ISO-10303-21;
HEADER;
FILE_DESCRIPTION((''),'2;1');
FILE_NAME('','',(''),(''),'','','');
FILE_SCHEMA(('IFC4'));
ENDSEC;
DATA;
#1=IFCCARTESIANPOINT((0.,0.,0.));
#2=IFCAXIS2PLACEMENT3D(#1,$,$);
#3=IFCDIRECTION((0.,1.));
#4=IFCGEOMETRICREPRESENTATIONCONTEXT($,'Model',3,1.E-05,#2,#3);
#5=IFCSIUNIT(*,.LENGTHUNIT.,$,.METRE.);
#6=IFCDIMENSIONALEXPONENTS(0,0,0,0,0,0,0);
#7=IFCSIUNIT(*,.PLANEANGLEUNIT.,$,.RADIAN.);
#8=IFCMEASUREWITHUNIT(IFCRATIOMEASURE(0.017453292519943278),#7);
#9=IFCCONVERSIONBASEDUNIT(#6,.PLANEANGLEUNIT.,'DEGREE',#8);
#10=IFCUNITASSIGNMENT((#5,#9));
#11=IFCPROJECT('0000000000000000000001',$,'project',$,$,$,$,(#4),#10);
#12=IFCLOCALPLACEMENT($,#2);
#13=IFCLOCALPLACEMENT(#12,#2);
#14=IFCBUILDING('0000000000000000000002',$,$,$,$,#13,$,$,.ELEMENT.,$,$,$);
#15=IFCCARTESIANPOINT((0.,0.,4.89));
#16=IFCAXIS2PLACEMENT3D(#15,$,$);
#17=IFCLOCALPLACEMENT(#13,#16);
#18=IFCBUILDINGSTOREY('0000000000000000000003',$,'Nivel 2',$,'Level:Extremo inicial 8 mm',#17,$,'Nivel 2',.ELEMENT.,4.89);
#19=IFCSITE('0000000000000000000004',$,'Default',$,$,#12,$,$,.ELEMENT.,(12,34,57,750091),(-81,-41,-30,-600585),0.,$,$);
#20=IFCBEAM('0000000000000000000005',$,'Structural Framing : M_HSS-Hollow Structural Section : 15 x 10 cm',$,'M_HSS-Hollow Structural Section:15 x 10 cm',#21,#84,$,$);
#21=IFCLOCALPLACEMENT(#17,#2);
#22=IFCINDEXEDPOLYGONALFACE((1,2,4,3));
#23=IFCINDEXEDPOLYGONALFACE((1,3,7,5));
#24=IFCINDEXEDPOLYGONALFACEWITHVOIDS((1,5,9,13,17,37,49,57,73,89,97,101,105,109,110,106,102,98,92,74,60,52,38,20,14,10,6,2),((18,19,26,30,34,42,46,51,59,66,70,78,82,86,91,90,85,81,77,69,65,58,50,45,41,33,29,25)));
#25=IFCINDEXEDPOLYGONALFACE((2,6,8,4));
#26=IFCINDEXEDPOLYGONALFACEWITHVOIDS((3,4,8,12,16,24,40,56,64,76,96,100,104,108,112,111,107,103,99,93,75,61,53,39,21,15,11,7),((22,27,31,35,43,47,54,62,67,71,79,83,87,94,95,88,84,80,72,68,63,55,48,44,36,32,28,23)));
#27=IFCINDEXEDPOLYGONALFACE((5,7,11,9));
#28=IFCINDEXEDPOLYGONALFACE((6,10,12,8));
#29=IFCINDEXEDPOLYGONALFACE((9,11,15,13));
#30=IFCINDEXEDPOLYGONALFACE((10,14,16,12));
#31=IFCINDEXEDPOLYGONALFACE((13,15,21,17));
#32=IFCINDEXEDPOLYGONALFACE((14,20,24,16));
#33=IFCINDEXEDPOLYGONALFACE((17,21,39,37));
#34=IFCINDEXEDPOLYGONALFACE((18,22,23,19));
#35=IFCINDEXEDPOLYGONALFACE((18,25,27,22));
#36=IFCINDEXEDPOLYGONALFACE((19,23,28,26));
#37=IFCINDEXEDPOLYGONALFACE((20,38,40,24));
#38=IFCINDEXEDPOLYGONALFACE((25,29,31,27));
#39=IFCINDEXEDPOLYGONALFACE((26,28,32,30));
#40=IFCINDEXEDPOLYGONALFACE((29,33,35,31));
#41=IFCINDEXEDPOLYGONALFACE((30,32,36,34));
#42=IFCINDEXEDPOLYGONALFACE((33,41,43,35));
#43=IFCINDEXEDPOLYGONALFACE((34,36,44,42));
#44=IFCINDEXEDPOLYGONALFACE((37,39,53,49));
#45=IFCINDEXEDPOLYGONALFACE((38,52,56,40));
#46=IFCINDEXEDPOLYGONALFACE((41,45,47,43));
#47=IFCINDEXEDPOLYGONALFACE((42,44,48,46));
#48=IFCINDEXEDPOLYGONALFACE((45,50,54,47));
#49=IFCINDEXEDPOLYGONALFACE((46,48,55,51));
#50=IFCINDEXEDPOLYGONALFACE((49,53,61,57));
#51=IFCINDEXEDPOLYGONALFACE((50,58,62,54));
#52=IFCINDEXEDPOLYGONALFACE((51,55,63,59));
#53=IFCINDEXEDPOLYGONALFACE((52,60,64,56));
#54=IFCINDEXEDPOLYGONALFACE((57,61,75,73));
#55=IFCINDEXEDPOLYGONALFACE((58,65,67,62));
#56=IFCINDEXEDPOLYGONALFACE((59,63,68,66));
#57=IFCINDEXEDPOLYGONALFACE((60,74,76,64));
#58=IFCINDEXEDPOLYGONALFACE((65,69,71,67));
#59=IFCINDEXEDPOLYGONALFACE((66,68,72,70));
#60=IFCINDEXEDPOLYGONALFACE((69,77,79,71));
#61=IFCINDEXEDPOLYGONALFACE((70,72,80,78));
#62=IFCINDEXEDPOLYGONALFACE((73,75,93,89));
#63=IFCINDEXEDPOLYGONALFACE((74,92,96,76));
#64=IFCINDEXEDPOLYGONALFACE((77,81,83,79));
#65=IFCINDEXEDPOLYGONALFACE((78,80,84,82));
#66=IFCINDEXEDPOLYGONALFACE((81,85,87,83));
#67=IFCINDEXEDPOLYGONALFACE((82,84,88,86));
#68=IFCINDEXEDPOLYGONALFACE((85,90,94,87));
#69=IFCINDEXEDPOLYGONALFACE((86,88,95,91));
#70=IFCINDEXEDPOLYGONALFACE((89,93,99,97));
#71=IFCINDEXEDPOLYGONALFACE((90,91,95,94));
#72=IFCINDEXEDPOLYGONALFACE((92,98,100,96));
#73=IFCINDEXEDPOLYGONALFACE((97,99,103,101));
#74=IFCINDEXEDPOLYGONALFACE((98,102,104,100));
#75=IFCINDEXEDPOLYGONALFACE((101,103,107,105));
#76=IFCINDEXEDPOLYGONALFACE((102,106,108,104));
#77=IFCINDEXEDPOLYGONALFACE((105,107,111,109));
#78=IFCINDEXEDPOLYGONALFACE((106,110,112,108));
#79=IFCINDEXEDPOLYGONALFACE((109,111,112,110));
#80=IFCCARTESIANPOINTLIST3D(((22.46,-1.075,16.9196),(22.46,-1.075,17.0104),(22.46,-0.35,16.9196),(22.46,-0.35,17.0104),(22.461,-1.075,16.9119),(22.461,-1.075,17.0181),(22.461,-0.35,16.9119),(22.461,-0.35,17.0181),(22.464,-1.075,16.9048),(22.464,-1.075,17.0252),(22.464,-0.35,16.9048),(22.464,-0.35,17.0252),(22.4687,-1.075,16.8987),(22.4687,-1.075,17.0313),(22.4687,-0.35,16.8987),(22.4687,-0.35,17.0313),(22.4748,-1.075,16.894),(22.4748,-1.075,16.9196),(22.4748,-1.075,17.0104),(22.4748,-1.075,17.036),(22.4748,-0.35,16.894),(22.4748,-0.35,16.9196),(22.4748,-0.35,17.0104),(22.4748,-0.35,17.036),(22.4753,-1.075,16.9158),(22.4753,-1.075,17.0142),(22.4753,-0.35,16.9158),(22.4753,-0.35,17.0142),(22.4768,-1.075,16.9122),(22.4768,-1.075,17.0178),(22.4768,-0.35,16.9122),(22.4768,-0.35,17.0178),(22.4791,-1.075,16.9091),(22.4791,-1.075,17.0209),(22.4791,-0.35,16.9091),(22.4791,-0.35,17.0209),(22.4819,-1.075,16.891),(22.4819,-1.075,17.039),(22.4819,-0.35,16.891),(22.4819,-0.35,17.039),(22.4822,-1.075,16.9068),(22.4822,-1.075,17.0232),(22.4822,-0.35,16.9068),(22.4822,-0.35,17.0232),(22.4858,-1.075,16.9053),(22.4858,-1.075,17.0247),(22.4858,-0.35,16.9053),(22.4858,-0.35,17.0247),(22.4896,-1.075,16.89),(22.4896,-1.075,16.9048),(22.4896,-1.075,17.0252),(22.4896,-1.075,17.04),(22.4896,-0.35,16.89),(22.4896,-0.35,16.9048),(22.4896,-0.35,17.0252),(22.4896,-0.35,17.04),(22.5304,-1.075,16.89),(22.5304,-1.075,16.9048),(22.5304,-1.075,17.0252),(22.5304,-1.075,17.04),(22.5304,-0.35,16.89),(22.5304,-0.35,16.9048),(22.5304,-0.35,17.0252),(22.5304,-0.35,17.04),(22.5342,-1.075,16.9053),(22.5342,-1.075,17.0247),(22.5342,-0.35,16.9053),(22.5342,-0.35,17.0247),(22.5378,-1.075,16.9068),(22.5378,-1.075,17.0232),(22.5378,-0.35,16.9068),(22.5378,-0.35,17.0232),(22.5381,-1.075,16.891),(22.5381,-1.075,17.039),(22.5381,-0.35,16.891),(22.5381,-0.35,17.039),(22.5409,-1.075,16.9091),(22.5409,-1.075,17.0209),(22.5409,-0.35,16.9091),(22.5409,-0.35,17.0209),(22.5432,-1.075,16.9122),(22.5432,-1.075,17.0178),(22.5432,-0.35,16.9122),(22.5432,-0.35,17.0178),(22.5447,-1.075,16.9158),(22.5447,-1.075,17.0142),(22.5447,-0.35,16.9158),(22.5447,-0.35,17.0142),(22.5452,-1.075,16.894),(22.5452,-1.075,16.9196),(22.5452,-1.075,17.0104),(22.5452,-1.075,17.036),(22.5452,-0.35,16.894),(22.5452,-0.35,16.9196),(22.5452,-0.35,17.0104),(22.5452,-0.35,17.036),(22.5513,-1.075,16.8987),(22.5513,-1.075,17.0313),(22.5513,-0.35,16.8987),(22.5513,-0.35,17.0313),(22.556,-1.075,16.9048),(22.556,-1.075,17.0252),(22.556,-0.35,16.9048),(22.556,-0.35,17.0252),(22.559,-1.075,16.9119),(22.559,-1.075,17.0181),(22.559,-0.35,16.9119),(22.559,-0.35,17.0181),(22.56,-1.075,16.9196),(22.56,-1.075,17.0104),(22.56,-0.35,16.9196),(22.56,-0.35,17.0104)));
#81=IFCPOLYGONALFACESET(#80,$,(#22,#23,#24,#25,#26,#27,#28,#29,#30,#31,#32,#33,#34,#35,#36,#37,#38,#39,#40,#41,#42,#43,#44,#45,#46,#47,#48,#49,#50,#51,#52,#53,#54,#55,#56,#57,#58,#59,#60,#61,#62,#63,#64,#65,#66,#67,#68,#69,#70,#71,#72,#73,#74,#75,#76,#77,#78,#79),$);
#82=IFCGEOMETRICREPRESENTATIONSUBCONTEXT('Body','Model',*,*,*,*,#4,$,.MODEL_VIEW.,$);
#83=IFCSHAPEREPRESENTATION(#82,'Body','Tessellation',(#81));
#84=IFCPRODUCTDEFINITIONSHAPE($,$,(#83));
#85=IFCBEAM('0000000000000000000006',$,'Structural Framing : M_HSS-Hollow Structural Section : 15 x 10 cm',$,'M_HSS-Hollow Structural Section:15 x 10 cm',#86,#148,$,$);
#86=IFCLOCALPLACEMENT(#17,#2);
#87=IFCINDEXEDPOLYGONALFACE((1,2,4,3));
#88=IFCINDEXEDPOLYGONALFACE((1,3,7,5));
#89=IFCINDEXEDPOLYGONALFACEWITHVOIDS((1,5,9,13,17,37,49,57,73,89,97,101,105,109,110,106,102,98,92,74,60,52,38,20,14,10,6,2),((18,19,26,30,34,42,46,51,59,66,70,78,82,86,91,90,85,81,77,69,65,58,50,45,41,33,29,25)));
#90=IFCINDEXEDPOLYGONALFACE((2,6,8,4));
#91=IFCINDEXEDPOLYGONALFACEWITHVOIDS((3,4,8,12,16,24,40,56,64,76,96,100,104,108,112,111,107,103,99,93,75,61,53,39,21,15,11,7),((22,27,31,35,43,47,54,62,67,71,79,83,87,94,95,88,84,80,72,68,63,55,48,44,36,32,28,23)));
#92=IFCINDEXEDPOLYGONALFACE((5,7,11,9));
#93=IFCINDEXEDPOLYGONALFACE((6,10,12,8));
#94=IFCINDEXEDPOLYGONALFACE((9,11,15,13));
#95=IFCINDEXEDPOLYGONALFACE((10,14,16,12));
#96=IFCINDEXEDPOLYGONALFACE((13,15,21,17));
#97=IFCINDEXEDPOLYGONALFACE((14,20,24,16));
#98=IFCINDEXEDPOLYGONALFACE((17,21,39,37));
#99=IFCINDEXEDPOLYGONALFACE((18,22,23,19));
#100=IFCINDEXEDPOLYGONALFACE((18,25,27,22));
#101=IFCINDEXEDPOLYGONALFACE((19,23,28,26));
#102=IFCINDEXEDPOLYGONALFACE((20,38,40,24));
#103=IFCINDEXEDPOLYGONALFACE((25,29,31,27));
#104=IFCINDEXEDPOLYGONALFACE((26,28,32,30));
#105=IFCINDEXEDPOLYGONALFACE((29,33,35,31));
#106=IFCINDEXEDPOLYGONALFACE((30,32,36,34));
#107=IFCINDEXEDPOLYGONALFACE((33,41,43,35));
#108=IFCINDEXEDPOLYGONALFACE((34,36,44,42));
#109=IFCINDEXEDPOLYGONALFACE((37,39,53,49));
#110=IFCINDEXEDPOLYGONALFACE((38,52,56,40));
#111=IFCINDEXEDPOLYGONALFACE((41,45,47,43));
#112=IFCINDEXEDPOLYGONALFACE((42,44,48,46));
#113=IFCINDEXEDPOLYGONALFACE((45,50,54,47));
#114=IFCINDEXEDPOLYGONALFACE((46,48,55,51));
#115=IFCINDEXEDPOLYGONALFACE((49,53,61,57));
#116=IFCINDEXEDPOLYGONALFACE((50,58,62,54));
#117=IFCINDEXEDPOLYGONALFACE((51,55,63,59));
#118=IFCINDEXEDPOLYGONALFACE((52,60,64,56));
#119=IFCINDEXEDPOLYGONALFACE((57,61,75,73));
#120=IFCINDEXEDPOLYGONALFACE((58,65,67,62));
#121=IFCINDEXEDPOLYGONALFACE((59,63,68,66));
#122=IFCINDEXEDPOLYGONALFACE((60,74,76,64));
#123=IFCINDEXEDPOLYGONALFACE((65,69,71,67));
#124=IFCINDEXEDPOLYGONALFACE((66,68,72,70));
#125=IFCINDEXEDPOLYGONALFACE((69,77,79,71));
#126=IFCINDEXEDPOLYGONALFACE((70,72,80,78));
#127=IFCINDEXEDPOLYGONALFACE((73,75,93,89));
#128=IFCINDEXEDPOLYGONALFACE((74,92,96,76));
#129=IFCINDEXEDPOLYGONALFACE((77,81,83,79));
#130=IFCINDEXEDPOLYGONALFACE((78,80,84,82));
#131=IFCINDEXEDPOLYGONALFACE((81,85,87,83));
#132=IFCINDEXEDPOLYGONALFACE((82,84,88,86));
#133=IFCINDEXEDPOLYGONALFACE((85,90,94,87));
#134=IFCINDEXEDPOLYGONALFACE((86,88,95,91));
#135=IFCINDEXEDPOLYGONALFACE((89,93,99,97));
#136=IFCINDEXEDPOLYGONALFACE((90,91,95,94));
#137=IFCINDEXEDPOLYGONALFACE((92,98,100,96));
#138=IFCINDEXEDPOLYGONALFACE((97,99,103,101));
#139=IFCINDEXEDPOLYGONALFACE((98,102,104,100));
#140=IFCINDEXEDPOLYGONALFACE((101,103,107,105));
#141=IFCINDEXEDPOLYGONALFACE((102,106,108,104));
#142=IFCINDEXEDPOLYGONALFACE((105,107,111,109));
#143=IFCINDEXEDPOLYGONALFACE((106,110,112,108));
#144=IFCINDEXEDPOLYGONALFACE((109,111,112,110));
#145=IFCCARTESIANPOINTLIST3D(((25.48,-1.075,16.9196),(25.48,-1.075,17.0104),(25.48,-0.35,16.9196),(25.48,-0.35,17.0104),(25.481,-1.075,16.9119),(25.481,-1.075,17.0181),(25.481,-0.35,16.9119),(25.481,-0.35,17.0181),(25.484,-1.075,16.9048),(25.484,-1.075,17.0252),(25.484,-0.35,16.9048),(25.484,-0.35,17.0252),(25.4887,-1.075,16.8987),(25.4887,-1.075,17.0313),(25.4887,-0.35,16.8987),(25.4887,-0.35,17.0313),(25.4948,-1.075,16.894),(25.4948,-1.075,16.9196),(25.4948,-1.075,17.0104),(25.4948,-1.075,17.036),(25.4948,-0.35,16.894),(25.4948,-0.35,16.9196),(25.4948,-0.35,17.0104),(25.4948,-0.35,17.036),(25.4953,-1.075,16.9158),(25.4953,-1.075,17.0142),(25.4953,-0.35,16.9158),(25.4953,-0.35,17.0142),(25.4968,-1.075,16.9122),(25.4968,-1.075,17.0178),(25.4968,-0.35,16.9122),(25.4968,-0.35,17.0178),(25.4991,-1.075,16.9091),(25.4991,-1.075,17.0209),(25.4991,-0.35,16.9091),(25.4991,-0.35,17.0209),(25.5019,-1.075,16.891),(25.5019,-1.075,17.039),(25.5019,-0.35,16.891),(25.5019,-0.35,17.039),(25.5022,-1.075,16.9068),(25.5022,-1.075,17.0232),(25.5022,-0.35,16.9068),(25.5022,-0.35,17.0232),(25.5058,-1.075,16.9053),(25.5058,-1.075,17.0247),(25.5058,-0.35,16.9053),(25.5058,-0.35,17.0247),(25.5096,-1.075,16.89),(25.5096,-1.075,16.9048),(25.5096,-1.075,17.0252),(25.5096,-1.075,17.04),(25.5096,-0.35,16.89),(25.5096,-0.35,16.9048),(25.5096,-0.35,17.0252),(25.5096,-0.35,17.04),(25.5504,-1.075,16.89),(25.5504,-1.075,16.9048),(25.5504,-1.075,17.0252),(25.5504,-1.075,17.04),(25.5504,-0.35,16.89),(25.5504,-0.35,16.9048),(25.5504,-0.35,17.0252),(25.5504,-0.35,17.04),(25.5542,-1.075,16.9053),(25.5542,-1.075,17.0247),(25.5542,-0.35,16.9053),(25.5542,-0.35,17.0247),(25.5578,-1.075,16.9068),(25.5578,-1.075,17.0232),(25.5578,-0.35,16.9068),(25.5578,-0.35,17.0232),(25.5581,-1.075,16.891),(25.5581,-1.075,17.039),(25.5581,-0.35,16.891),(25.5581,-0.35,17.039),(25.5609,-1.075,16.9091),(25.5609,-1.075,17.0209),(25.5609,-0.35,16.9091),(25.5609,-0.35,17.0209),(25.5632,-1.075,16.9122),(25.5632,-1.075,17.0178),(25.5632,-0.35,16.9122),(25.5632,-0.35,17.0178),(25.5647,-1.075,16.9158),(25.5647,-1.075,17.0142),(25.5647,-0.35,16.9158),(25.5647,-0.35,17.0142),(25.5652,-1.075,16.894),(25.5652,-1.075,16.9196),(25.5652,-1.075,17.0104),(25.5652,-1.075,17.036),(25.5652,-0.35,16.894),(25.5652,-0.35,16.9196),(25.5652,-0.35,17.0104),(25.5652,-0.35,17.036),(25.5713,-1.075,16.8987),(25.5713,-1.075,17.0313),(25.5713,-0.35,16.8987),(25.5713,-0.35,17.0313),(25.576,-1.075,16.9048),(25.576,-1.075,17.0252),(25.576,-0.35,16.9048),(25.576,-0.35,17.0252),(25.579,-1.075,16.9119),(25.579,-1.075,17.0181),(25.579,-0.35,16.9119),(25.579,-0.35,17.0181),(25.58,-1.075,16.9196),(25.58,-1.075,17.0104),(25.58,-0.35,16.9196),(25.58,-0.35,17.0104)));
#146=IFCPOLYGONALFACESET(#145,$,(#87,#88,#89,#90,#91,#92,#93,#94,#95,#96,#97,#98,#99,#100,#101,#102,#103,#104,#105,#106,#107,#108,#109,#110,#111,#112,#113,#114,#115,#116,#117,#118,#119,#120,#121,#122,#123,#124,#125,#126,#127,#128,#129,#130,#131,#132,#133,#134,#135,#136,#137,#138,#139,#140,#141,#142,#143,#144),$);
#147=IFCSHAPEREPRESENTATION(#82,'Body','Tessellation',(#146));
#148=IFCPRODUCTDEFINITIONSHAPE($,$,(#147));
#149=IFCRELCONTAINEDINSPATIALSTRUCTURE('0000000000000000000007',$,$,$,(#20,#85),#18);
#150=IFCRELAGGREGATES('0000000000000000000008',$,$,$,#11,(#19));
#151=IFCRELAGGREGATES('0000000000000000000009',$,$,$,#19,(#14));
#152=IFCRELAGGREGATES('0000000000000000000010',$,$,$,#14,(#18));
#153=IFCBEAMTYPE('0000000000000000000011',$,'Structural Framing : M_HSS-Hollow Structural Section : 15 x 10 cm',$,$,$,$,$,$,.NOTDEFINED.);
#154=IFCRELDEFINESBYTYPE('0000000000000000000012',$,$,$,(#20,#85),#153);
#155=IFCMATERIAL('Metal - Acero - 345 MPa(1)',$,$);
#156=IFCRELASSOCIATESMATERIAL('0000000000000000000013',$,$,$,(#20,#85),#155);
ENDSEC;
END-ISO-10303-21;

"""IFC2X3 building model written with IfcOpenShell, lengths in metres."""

from ifc_helpers import new_model, entity, si_unit, converted_unit, direction, frame, frame_2d, origin, place, context, subcontext, project, spatial, polyline, circle_curve, parameter, trimmed, segment, composite_curve, outline, extrude, material, type_object, element, save


model = new_model("IFC2X3")

# Units and contexts
model_context = context("Model", 3, precision=1e-05, world=origin(), true_north=direction((0.0, 1.0)))
body_context = subcontext(model_context, "Body", "Model", "MODEL_VIEW")
ifc_project = project(units=[si_unit("LENGTHUNIT", "METRE"), converted_unit("PLANEANGLEUNIT", "DEGREE", entity("IfcRatioMeasure", 0.017453292519943278), si_unit("PLANEANGLEUNIT", "RADIAN"), dimensions=[0, 0, 0, 0, 0, 0, 0])], contexts=[model_context])

# Site, building, storey
site_placement = place(None, origin())
site = spatial("IfcSite", under=ifc_project, at=site_placement, Name="Default", CompositionType="ELEMENT", RefLatitude=(12, 34, 57, 750091), RefLongitude=(-81, -41, -30, -600585), RefElevation=0.0)
building_placement = place(site_placement, origin())
building = spatial("IfcBuilding", under=site, at=building_placement, CompositionType="ELEMENT")
storey_placement = place(building_placement, frame((0.0, 0.0, 4.89)))
storey = spatial("IfcBuildingStorey", under=building, at=storey_placement, Name="Nivel 2", ObjectType="Level:Extremo inicial 8 mm", LongName="Nivel 2", CompositionType="ELEMENT", Elevation=4.89)

# Beams
ifc_material_1 = material(Name="Metal - Acero - 345 MPa(1)")
beam_type_1 = type_object("IfcBeamType", Name="Structural Framing : M_HSS-Hollow Structural Section : 15 x 10 cm", PredefinedType="NOTDEFINED")
beam_1_placement = place(storey_placement, frame((22.51, -1.425, 17.04), z_axis=(0.0, 0.0, 1.0), x_axis=(0.0, 1.0, 0.0)))
element("IfcBeam", 1, at=beam_1_placement, inside=storey, type_object=beam_type_1, material=ifc_material_1, Name="Structural Framing : M_HSS-Hollow Structural Section : 15 x 10 cm", ObjectType="M_HSS-Hollow Structural Section:15 x 10 cm", context=body_context, shape_type="SweptSolid", body=[
    extrude(outline(composite_curve([segment(trimmed(circle_curve(frame_2d((-0.0204, -0.0454), x_axis=(1.0, 0.0)), 0.0296), [parameter(180.0)], [parameter(270.0)], True, "PARAMETER"), True, "CONTINUOUS"), segment(polyline([(-0.0204, -0.075), (0.0204, -0.075)]), True, "CONTINUOUS"), segment(trimmed(circle_curve(frame_2d((0.0204, -0.0454), x_axis=(1.0, 0.0)), 0.0296), [parameter(270.0)], [parameter(0.0)], True, "PARAMETER"), True, "CONTINUOUS"), segment(polyline([(0.05, -0.0454), (0.05, 0.0454)]), True, "CONTINUOUS"), segment(trimmed(circle_curve(frame_2d((0.0204, 0.0454), x_axis=(1.0, 0.0)), 0.0296), [parameter(360.0)], [parameter(90.0)], True, "PARAMETER"), True, "CONTINUOUS"), segment(polyline([(0.0204, 0.075), (-0.0204, 0.075)]), True, "CONTINUOUS"), segment(trimmed(circle_curve(frame_2d((-0.0204, 0.0454), x_axis=(1.0, 0.0)), 0.0296), [parameter(90.0)], [parameter(180.0)], True, "PARAMETER"), True, "CONTINUOUS"), segment(polyline([(-0.05, 0.0454), (-0.05, -0.0454)]), True, "CONTINUOUS")], self_intersect=False), holes=[composite_curve([segment(polyline([(0.0204, -0.0602), (-0.0204, -0.0602)]), True, "CONTINUOUS"), segment(trimmed(circle_curve(frame_2d((-0.0204, -0.0454), x_axis=(1.0, 0.0)), 0.0148), [parameter(180.0)], [parameter(270.0)], True, "PARAMETER"), False, "CONTINUOUS"), segment(polyline([(-0.0352, -0.0454), (-0.0352, 0.0454)]), True, "CONTINUOUS"), segment(trimmed(circle_curve(frame_2d((-0.0204, 0.0454), x_axis=(1.0, 0.0)), 0.0148), [parameter(90.0)], [parameter(180.0)], True, "PARAMETER"), False, "CONTINUOUS"), segment(polyline([(-0.0204, 0.0602), (0.0204, 0.0602)]), True, "CONTINUOUS"), segment(trimmed(circle_curve(frame_2d((0.0204, 0.0454), x_axis=(1.0, 0.0)), 0.0148), [parameter(0.0)], [parameter(90.0)], True, "PARAMETER"), False, "CONTINUOUS"), segment(polyline([(0.0352, 0.0454), (0.0352, -0.0454)]), True, "CONTINUOUS"), segment(trimmed(circle_curve(frame_2d((0.0204, -0.0454), x_axis=(1.0, 0.0)), 0.0148), [parameter(270.0)], [parameter(0.0)], True, "PARAMETER"), False, "CONTINUOUS")], self_intersect=False)]), frame((0.35, 0.0, -0.075), z_axis=(1.0, 0.0, 0.0), x_axis=(0.0, -1.0, 0.0)), (0.0, 0.0, 1.0), 0.725),
])
beam_2_placement = place(storey_placement, frame((25.53, -1.425, 17.04), z_axis=(0.0, 0.0, 1.0), x_axis=(0.0, 1.0, 0.0)))
element("IfcBeam", 2, at=beam_2_placement, inside=storey, type_object=beam_type_1, material=ifc_material_1, Name="Structural Framing : M_HSS-Hollow Structural Section : 15 x 10 cm", ObjectType="M_HSS-Hollow Structural Section:15 x 10 cm", context=body_context, shape_type="SweptSolid", body=[
    extrude(outline(composite_curve([segment(trimmed(circle_curve(frame_2d((-0.0204, -0.0454), x_axis=(1.0, 0.0)), 0.0296), [parameter(180.0)], [parameter(270.0)], True, "PARAMETER"), True, "CONTINUOUS"), segment(polyline([(-0.0204, -0.075), (0.0204, -0.075)]), True, "CONTINUOUS"), segment(trimmed(circle_curve(frame_2d((0.0204, -0.0454), x_axis=(1.0, 0.0)), 0.0296), [parameter(270.0)], [parameter(0.0)], True, "PARAMETER"), True, "CONTINUOUS"), segment(polyline([(0.05, -0.0454), (0.05, 0.0454)]), True, "CONTINUOUS"), segment(trimmed(circle_curve(frame_2d((0.0204, 0.0454), x_axis=(1.0, 0.0)), 0.0296), [parameter(360.0)], [parameter(90.0)], True, "PARAMETER"), True, "CONTINUOUS"), segment(polyline([(0.0204, 0.075), (-0.0204, 0.075)]), True, "CONTINUOUS"), segment(trimmed(circle_curve(frame_2d((-0.0204, 0.0454), x_axis=(1.0, 0.0)), 0.0296), [parameter(90.0)], [parameter(180.0)], True, "PARAMETER"), True, "CONTINUOUS"), segment(polyline([(-0.05, 0.0454), (-0.05, -0.0454)]), True, "CONTINUOUS")], self_intersect=False), holes=[composite_curve([segment(polyline([(0.0204, -0.0602), (-0.0204, -0.0602)]), True, "CONTINUOUS"), segment(trimmed(circle_curve(frame_2d((-0.0204, -0.0454), x_axis=(1.0, 0.0)), 0.0148), [parameter(180.0)], [parameter(270.0)], True, "PARAMETER"), False, "CONTINUOUS"), segment(polyline([(-0.0352, -0.0454), (-0.0352, 0.0454)]), True, "CONTINUOUS"), segment(trimmed(circle_curve(frame_2d((-0.0204, 0.0454), x_axis=(1.0, 0.0)), 0.0148), [parameter(90.0)], [parameter(180.0)], True, "PARAMETER"), False, "CONTINUOUS"), segment(polyline([(-0.0204, 0.0602), (0.0204, 0.0602)]), True, "CONTINUOUS"), segment(trimmed(circle_curve(frame_2d((0.0204, 0.0454), x_axis=(1.0, 0.0)), 0.0148), [parameter(0.0)], [parameter(90.0)], True, "PARAMETER"), False, "CONTINUOUS"), segment(polyline([(0.0352, 0.0454), (0.0352, -0.0454)]), True, "CONTINUOUS"), segment(trimmed(circle_curve(frame_2d((0.0204, -0.0454), x_axis=(1.0, 0.0)), 0.0148), [parameter(270.0)], [parameter(0.0)], True, "PARAMETER"), False, "CONTINUOUS")], self_intersect=False)]), frame((0.35, 0.0, -0.075), z_axis=(1.0, 0.0, 0.0), x_axis=(0.0, -1.0, 0.0)), (0.0, 0.0, 1.0), 0.725),
])

save(model, "model.ifc")
